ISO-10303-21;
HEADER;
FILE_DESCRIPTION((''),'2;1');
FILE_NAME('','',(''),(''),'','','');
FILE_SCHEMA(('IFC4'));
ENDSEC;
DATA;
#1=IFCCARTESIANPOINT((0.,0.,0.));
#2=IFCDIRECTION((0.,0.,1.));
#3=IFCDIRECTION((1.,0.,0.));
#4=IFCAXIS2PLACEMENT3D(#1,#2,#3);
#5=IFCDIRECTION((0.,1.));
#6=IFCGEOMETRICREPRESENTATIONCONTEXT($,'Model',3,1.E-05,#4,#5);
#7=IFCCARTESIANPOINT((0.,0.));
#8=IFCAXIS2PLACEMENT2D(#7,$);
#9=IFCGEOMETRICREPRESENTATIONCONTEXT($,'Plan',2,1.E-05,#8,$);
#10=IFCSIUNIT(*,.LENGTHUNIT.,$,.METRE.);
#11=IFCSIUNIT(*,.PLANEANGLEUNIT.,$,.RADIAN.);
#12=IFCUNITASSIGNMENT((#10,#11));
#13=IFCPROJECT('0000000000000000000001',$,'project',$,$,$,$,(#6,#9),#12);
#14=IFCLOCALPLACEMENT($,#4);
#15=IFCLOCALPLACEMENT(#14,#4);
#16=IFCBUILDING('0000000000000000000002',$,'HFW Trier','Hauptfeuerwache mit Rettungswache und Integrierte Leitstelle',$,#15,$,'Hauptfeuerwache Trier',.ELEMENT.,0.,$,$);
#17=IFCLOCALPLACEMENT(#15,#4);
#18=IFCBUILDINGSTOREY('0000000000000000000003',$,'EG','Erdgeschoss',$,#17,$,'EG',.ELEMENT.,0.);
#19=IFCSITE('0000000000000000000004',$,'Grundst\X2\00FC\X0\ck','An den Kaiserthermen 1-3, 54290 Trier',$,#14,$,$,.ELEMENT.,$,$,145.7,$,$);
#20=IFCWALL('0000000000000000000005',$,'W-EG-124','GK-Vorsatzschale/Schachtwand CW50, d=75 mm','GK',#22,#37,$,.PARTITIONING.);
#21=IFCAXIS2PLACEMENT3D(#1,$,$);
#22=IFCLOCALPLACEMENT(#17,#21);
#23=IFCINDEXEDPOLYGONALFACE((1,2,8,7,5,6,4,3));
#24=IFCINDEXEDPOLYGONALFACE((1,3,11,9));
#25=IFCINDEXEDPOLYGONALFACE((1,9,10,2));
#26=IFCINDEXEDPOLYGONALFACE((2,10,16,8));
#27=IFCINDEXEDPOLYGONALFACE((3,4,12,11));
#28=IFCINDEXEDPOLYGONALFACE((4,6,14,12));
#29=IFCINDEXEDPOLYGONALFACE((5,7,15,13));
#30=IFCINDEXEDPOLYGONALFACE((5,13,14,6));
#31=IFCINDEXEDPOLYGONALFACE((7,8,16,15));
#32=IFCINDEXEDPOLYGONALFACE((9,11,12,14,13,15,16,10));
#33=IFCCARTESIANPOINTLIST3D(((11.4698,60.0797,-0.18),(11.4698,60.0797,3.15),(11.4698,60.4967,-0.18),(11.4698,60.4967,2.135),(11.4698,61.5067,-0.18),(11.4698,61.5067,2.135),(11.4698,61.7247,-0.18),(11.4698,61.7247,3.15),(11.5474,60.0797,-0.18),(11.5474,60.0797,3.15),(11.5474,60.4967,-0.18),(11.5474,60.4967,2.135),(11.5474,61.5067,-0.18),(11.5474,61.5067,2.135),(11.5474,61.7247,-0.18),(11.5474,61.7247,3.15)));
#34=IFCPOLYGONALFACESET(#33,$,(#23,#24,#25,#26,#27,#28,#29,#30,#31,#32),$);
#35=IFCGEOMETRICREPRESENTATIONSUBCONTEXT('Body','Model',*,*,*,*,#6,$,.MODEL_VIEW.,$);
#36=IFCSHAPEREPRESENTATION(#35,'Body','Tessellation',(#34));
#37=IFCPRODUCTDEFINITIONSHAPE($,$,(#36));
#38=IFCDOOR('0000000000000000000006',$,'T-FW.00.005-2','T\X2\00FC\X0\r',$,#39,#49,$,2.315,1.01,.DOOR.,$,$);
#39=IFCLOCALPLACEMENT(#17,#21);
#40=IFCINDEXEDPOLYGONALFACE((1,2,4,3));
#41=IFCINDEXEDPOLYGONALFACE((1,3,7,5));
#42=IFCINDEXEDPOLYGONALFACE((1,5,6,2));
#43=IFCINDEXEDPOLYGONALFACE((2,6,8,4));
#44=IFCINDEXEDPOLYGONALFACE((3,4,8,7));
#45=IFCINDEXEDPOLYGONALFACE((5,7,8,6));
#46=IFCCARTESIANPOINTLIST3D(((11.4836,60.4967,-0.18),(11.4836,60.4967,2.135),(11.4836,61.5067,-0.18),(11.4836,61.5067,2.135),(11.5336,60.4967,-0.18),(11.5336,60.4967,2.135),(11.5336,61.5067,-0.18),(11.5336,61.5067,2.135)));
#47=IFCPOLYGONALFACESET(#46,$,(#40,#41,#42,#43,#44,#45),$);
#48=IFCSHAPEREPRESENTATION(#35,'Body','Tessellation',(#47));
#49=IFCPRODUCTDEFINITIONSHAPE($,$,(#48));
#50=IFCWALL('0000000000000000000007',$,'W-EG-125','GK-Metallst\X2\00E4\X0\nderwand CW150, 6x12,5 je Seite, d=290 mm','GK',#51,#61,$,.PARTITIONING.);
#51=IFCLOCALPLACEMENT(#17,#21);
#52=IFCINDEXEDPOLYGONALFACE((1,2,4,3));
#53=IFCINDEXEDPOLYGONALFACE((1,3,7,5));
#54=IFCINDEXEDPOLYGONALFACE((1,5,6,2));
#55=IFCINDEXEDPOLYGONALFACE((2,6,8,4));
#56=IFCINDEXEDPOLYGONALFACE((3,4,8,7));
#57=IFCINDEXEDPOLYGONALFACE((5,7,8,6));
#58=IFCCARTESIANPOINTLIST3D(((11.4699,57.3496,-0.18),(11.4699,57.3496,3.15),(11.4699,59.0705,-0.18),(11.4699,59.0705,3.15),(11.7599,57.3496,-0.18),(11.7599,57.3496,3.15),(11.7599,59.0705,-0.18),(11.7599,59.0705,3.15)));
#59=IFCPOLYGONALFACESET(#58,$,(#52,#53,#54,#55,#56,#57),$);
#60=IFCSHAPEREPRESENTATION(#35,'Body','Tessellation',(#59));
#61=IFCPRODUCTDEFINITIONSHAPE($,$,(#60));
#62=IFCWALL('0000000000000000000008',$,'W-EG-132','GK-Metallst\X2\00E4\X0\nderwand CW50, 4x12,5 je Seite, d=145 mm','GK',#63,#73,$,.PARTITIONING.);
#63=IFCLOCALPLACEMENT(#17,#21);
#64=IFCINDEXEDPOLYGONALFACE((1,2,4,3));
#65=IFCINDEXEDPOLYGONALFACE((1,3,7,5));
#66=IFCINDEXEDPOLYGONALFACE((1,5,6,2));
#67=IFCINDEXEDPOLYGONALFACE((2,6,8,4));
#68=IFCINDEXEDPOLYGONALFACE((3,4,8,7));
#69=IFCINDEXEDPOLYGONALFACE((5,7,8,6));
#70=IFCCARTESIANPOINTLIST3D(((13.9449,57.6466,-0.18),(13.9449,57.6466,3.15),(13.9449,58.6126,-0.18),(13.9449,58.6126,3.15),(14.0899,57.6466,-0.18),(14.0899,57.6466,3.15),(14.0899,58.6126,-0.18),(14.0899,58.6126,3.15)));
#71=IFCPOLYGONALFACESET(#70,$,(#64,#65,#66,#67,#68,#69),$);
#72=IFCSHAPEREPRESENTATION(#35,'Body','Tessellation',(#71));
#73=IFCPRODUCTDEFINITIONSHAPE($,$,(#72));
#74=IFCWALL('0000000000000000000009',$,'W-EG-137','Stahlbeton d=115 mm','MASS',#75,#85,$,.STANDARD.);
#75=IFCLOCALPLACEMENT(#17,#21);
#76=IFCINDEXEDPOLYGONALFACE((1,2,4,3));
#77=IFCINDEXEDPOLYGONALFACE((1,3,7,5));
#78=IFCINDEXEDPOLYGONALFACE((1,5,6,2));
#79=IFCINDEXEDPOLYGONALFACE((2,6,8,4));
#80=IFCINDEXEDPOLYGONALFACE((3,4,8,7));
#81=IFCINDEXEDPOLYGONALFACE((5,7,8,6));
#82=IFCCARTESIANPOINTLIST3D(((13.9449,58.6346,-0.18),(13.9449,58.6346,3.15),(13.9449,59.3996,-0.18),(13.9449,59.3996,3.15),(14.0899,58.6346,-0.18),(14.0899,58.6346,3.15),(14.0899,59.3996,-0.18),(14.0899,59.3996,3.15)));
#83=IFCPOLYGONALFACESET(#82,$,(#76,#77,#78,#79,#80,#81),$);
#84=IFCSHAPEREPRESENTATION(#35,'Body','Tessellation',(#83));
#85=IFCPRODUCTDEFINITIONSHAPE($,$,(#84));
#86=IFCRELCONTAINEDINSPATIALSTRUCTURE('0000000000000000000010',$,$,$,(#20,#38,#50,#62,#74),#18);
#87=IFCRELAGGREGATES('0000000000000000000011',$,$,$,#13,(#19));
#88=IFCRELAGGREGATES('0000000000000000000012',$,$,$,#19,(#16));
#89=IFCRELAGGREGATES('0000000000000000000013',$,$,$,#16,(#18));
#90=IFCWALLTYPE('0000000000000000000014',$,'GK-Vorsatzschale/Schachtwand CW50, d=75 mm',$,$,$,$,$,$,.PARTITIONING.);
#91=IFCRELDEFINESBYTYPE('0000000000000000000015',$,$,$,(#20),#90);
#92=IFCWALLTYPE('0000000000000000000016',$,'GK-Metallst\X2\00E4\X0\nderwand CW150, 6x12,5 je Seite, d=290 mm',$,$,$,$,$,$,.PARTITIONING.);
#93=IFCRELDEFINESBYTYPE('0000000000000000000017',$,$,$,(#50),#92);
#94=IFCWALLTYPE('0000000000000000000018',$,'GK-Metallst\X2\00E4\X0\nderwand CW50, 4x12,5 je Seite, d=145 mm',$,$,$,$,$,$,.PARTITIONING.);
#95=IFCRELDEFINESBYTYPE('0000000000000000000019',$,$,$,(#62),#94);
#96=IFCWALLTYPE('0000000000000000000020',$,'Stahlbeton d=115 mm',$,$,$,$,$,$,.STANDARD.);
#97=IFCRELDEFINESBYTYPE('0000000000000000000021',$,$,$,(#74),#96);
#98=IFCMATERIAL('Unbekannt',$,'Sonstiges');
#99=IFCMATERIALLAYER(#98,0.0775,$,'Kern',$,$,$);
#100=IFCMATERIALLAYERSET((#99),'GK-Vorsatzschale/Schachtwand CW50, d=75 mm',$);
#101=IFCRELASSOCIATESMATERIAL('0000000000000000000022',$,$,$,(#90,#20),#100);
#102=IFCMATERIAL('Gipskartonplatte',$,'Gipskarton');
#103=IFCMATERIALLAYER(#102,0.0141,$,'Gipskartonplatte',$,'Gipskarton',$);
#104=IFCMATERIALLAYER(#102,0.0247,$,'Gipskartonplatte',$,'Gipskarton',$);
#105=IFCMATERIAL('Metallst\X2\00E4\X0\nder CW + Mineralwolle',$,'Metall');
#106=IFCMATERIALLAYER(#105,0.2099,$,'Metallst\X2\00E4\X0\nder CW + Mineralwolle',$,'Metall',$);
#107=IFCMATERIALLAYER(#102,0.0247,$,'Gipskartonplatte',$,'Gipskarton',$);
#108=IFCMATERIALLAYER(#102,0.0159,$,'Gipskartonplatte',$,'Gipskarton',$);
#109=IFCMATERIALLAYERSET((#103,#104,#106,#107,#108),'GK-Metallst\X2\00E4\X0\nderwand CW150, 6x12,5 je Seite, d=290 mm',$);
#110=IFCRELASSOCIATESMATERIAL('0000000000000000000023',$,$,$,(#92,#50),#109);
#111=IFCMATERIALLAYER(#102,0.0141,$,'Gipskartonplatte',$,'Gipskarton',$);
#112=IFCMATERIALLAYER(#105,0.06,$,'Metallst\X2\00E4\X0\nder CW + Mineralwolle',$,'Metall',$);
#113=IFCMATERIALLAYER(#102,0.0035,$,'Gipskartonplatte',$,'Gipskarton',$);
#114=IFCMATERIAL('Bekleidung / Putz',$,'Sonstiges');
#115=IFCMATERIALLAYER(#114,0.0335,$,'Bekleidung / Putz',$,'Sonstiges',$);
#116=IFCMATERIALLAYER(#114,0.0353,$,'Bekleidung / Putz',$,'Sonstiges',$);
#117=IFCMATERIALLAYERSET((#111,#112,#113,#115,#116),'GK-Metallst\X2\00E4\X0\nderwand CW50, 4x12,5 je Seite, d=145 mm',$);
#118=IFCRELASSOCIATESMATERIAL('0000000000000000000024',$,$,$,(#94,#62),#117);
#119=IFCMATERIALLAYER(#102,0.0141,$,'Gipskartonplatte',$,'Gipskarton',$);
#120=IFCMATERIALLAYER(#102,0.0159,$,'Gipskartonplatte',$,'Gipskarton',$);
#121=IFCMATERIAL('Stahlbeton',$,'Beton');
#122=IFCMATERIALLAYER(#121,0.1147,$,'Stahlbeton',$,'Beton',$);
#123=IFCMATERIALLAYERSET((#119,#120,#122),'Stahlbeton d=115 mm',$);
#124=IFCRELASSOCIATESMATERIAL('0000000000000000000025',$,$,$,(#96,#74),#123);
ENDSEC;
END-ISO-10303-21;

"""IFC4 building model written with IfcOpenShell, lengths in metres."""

from ifc_helpers import new_model, si_unit, direction, frame, frame_2d, origin_with_axes, origin_2d, place, context, subcontext, project, spatial, rectangle, extrude, material, layer, layer_set, layer_usage, type_object, element, fill, save


model = new_model("IFC4")

# Units and contexts
model_context = context("Model", 3, precision=1e-05, world=origin_with_axes(), true_north=direction((0.0, 1.0)))
plan_context = context("Plan", 2, precision=1e-05, world=origin_2d())
body_context = subcontext(model_context, "Body", "Model", "MODEL_VIEW")
ifc_project = project(units=[si_unit("LENGTHUNIT", "METRE"), si_unit("PLANEANGLEUNIT", "RADIAN")], contexts=[model_context, plan_context])

# Site, building, storey
site_placement = place(None, origin_with_axes())
site = spatial("IfcSite", under=ifc_project, at=site_placement, Name="Grundstück", Description="An den Kaiserthermen 1-3, 54290 Trier", CompositionType="ELEMENT", RefElevation=145.7)
building_placement = place(site_placement, origin_with_axes())
building = spatial("IfcBuilding", under=site, at=building_placement, Name="HFW Trier", Description="Hauptfeuerwache mit Rettungswache und Integrierte Leitstelle", LongName="Hauptfeuerwache Trier", CompositionType="ELEMENT", ElevationOfRefHeight=0.0)
storey_placement = place(building_placement, origin_with_axes())
storey = spatial("IfcBuildingStorey", under=building, at=storey_placement, Name="EG", Description="Erdgeschoss", LongName="EG", CompositionType="ELEMENT", Elevation=0.0)

# Shared definitions
ifc_material_1 = material(Name="Stahlbeton", Category="Beton")

# Shared definitions
ifc_material_2 = material(Name="Gipskartonplatte", Category="Gipskarton")
ifc_material_3 = material(Name="Metallständer CW + Mineralwolle", Category="Metall")

# Shared definitions
ifc_material_4 = material(Name="Unbekannt", Category="Sonstiges")

# Wall, opening, door
ifc_layer_1 = layer(ifc_material_4, 0.0775, Name="Kern")
ifc_layer_set_1 = layer_set([ifc_layer_1], Name="GK-Vorsatzschale/Schachtwand CW50, d=75 mm")
ifc_layer_usage_1 = layer_usage(ifc_layer_set_1, "AXIS2", "POSITIVE", -0.0387)
wall_type_1 = type_object("IfcWallType", Name="GK-Vorsatzschale/Schachtwand CW50, d=75 mm", PredefinedType="PARTITIONING", material=ifc_layer_set_1)
wall_1_placement = place(storey_placement, frame((11.5086, 61.7247, -0.18), z_axis=(0.0, 0.0, 1.0), x_axis=(0.0, -1.0, 0.0)))
wall_1 = element("IfcWall", 1, at=wall_1_placement, inside=storey, type_object=wall_type_1, material=ifc_layer_usage_1, Name="W-EG-124", Description="GK-Vorsatzschale/Schachtwand CW50, d=75 mm", ObjectType="GK", PredefinedType="PARTITIONING", context=body_context, shape_type="SweptSolid", body=[
    extrude(rectangle(XDim=1.645, YDim=0.0775, at=frame_2d((0.8225, 0.0))), origin_with_axes(), (0.0, 0.0, 1.0), 3.33),
])
opening_1_placement = place(wall_1_placement, frame((0.218, 0.0, 0.0), z_axis=(0.0, 0.0, 1.0), x_axis=(1.0, 0.0, 0.0)))
opening_1 = element("IfcOpeningElement", 2, at=opening_1_placement, cuts=wall_1, PredefinedType="OPENING", context=body_context, shape_type="SweptSolid", body=[
    extrude(rectangle(XDim=1.01, YDim=0.1775, at=frame_2d((0.505, 0.0))), origin_with_axes(), (0.0, 0.0, 1.0), 2.315),
])
door_1_placement = place(wall_1_placement, frame((0.218, 0.0, 0.0), z_axis=(0.0, 0.0, 1.0), x_axis=(1.0, 0.0, 0.0)))
door_1 = element("IfcDoor", 3, at=door_1_placement, inside=storey, Name="T-FW.00.005-2", Description="Tür", OverallHeight=2.315, OverallWidth=1.01, PredefinedType="DOOR", context=body_context, shape_type="SweptSolid", body=[
    extrude(rectangle(XDim=1.01, YDim=0.05, at=frame_2d((0.505, 0.0))), origin_with_axes(), (0.0, 0.0, 1.0), 2.315),
])
fill(opening_1, door_1)

# Walls
ifc_layer_2 = layer(ifc_material_2, 0.0141, Name="Gipskartonplatte", Category="Gipskarton")
ifc_layer_3 = layer(ifc_material_2, 0.0247, Name="Gipskartonplatte", Category="Gipskarton")
ifc_layer_4 = layer(ifc_material_3, 0.2099, Name="Metallständer CW + Mineralwolle", Category="Metall")
ifc_layer_5 = layer(ifc_material_2, 0.0247, Name="Gipskartonplatte", Category="Gipskarton")
ifc_layer_6 = layer(ifc_material_2, 0.0159, Name="Gipskartonplatte", Category="Gipskarton")
ifc_layer_set_2 = layer_set([ifc_layer_2, ifc_layer_3, ifc_layer_4, ifc_layer_5, ifc_layer_6], Name="GK-Metallständerwand CW150, 6x12,5 je Seite, d=290 mm")
ifc_layer_usage_2 = layer_usage(ifc_layer_set_2, "AXIS2", "POSITIVE", -0.145)
wall_type_2 = type_object("IfcWallType", Name="GK-Metallständerwand CW150, 6x12,5 je Seite, d=290 mm", PredefinedType="PARTITIONING", material=ifc_layer_set_2)
wall_2_placement = place(storey_placement, frame((11.6149, 59.0705, -0.18), z_axis=(0.0, 0.0, 1.0), x_axis=(0.0, -1.0, 0.0)))
element("IfcWall", 4, at=wall_2_placement, inside=storey, type_object=wall_type_2, material=ifc_layer_usage_2, Name="W-EG-125", Description="GK-Metallständerwand CW150, 6x12,5 je Seite, d=290 mm", ObjectType="GK", PredefinedType="PARTITIONING", context=body_context, shape_type="SweptSolid", body=[
    extrude(rectangle(XDim=1.7209, YDim=0.29, at=frame_2d((0.8605, 0.0))), origin_with_axes(), (0.0, 0.0, 1.0), 3.33),
])
ifc_layer_7 = layer(ifc_material_2, 0.0141, Name="Gipskartonplatte", Category="Gipskarton")
ifc_layer_8 = layer(ifc_material_3, 0.06, Name="Metallständer CW + Mineralwolle", Category="Metall")
ifc_layer_9 = layer(ifc_material_2, 0.0035, Name="Gipskartonplatte", Category="Gipskarton")
ifc_material_5 = material(Name="Bekleidung / Putz", Category="Sonstiges")
ifc_layer_10 = layer(ifc_material_5, 0.0335, Name="Bekleidung / Putz", Category="Sonstiges")
ifc_layer_11 = layer(ifc_material_5, 0.0353, Name="Bekleidung / Putz", Category="Sonstiges")
ifc_layer_set_3 = layer_set([ifc_layer_7, ifc_layer_8, ifc_layer_9, ifc_layer_10, ifc_layer_11], Name="GK-Metallständerwand CW50, 4x12,5 je Seite, d=145 mm")
ifc_layer_usage_3 = layer_usage(ifc_layer_set_3, "AXIS2", "POSITIVE", -0.0725)
wall_type_3 = type_object("IfcWallType", Name="GK-Metallständerwand CW50, 4x12,5 je Seite, d=145 mm", PredefinedType="PARTITIONING", material=ifc_layer_set_3)
wall_3_placement = place(storey_placement, frame((14.0174, 58.6126, -0.18), z_axis=(0.0, 0.0, 1.0), x_axis=(0.0, -1.0, 0.0)))
element("IfcWall", 5, at=wall_3_placement, inside=storey, type_object=wall_type_3, material=ifc_layer_usage_3, Name="W-EG-132", Description="GK-Metallständerwand CW50, 4x12,5 je Seite, d=145 mm", ObjectType="GK", PredefinedType="PARTITIONING", context=body_context, shape_type="SweptSolid", body=[
    extrude(rectangle(XDim=0.966, YDim=0.145, at=frame_2d((0.483, 0.0))), origin_with_axes(), (0.0, 0.0, 1.0), 3.33),
])
ifc_layer_12 = layer(ifc_material_2, 0.0141, Name="Gipskartonplatte", Category="Gipskarton")
ifc_layer_13 = layer(ifc_material_2, 0.0159, Name="Gipskartonplatte", Category="Gipskarton")
ifc_layer_14 = layer(ifc_material_1, 0.1147, Name="Stahlbeton", Category="Beton")
ifc_layer_set_4 = layer_set([ifc_layer_12, ifc_layer_13, ifc_layer_14], Name="Stahlbeton d=115 mm")
ifc_layer_usage_4 = layer_usage(ifc_layer_set_4, "AXIS2", "POSITIVE", -0.0725)
wall_type_4 = type_object("IfcWallType", Name="Stahlbeton d=115 mm", PredefinedType="STANDARD", material=ifc_layer_set_4)
wall_4_placement = place(storey_placement, frame((14.0174, 59.3996, -0.18), z_axis=(0.0, 0.0, 1.0), x_axis=(0.0, -1.0, 0.0)))
element("IfcWall", 6, at=wall_4_placement, inside=storey, type_object=wall_type_4, material=ifc_layer_usage_4, Name="W-EG-137", Description="Stahlbeton d=115 mm", ObjectType="MASS", PredefinedType="STANDARD", context=body_context, shape_type="SweptSolid", body=[
    extrude(rectangle(XDim=0.765, YDim=0.145, at=frame_2d((0.3825, 0.0))), origin_with_axes(), (0.0, 0.0, 1.0), 3.33),
])

save(model, "model.ifc")
